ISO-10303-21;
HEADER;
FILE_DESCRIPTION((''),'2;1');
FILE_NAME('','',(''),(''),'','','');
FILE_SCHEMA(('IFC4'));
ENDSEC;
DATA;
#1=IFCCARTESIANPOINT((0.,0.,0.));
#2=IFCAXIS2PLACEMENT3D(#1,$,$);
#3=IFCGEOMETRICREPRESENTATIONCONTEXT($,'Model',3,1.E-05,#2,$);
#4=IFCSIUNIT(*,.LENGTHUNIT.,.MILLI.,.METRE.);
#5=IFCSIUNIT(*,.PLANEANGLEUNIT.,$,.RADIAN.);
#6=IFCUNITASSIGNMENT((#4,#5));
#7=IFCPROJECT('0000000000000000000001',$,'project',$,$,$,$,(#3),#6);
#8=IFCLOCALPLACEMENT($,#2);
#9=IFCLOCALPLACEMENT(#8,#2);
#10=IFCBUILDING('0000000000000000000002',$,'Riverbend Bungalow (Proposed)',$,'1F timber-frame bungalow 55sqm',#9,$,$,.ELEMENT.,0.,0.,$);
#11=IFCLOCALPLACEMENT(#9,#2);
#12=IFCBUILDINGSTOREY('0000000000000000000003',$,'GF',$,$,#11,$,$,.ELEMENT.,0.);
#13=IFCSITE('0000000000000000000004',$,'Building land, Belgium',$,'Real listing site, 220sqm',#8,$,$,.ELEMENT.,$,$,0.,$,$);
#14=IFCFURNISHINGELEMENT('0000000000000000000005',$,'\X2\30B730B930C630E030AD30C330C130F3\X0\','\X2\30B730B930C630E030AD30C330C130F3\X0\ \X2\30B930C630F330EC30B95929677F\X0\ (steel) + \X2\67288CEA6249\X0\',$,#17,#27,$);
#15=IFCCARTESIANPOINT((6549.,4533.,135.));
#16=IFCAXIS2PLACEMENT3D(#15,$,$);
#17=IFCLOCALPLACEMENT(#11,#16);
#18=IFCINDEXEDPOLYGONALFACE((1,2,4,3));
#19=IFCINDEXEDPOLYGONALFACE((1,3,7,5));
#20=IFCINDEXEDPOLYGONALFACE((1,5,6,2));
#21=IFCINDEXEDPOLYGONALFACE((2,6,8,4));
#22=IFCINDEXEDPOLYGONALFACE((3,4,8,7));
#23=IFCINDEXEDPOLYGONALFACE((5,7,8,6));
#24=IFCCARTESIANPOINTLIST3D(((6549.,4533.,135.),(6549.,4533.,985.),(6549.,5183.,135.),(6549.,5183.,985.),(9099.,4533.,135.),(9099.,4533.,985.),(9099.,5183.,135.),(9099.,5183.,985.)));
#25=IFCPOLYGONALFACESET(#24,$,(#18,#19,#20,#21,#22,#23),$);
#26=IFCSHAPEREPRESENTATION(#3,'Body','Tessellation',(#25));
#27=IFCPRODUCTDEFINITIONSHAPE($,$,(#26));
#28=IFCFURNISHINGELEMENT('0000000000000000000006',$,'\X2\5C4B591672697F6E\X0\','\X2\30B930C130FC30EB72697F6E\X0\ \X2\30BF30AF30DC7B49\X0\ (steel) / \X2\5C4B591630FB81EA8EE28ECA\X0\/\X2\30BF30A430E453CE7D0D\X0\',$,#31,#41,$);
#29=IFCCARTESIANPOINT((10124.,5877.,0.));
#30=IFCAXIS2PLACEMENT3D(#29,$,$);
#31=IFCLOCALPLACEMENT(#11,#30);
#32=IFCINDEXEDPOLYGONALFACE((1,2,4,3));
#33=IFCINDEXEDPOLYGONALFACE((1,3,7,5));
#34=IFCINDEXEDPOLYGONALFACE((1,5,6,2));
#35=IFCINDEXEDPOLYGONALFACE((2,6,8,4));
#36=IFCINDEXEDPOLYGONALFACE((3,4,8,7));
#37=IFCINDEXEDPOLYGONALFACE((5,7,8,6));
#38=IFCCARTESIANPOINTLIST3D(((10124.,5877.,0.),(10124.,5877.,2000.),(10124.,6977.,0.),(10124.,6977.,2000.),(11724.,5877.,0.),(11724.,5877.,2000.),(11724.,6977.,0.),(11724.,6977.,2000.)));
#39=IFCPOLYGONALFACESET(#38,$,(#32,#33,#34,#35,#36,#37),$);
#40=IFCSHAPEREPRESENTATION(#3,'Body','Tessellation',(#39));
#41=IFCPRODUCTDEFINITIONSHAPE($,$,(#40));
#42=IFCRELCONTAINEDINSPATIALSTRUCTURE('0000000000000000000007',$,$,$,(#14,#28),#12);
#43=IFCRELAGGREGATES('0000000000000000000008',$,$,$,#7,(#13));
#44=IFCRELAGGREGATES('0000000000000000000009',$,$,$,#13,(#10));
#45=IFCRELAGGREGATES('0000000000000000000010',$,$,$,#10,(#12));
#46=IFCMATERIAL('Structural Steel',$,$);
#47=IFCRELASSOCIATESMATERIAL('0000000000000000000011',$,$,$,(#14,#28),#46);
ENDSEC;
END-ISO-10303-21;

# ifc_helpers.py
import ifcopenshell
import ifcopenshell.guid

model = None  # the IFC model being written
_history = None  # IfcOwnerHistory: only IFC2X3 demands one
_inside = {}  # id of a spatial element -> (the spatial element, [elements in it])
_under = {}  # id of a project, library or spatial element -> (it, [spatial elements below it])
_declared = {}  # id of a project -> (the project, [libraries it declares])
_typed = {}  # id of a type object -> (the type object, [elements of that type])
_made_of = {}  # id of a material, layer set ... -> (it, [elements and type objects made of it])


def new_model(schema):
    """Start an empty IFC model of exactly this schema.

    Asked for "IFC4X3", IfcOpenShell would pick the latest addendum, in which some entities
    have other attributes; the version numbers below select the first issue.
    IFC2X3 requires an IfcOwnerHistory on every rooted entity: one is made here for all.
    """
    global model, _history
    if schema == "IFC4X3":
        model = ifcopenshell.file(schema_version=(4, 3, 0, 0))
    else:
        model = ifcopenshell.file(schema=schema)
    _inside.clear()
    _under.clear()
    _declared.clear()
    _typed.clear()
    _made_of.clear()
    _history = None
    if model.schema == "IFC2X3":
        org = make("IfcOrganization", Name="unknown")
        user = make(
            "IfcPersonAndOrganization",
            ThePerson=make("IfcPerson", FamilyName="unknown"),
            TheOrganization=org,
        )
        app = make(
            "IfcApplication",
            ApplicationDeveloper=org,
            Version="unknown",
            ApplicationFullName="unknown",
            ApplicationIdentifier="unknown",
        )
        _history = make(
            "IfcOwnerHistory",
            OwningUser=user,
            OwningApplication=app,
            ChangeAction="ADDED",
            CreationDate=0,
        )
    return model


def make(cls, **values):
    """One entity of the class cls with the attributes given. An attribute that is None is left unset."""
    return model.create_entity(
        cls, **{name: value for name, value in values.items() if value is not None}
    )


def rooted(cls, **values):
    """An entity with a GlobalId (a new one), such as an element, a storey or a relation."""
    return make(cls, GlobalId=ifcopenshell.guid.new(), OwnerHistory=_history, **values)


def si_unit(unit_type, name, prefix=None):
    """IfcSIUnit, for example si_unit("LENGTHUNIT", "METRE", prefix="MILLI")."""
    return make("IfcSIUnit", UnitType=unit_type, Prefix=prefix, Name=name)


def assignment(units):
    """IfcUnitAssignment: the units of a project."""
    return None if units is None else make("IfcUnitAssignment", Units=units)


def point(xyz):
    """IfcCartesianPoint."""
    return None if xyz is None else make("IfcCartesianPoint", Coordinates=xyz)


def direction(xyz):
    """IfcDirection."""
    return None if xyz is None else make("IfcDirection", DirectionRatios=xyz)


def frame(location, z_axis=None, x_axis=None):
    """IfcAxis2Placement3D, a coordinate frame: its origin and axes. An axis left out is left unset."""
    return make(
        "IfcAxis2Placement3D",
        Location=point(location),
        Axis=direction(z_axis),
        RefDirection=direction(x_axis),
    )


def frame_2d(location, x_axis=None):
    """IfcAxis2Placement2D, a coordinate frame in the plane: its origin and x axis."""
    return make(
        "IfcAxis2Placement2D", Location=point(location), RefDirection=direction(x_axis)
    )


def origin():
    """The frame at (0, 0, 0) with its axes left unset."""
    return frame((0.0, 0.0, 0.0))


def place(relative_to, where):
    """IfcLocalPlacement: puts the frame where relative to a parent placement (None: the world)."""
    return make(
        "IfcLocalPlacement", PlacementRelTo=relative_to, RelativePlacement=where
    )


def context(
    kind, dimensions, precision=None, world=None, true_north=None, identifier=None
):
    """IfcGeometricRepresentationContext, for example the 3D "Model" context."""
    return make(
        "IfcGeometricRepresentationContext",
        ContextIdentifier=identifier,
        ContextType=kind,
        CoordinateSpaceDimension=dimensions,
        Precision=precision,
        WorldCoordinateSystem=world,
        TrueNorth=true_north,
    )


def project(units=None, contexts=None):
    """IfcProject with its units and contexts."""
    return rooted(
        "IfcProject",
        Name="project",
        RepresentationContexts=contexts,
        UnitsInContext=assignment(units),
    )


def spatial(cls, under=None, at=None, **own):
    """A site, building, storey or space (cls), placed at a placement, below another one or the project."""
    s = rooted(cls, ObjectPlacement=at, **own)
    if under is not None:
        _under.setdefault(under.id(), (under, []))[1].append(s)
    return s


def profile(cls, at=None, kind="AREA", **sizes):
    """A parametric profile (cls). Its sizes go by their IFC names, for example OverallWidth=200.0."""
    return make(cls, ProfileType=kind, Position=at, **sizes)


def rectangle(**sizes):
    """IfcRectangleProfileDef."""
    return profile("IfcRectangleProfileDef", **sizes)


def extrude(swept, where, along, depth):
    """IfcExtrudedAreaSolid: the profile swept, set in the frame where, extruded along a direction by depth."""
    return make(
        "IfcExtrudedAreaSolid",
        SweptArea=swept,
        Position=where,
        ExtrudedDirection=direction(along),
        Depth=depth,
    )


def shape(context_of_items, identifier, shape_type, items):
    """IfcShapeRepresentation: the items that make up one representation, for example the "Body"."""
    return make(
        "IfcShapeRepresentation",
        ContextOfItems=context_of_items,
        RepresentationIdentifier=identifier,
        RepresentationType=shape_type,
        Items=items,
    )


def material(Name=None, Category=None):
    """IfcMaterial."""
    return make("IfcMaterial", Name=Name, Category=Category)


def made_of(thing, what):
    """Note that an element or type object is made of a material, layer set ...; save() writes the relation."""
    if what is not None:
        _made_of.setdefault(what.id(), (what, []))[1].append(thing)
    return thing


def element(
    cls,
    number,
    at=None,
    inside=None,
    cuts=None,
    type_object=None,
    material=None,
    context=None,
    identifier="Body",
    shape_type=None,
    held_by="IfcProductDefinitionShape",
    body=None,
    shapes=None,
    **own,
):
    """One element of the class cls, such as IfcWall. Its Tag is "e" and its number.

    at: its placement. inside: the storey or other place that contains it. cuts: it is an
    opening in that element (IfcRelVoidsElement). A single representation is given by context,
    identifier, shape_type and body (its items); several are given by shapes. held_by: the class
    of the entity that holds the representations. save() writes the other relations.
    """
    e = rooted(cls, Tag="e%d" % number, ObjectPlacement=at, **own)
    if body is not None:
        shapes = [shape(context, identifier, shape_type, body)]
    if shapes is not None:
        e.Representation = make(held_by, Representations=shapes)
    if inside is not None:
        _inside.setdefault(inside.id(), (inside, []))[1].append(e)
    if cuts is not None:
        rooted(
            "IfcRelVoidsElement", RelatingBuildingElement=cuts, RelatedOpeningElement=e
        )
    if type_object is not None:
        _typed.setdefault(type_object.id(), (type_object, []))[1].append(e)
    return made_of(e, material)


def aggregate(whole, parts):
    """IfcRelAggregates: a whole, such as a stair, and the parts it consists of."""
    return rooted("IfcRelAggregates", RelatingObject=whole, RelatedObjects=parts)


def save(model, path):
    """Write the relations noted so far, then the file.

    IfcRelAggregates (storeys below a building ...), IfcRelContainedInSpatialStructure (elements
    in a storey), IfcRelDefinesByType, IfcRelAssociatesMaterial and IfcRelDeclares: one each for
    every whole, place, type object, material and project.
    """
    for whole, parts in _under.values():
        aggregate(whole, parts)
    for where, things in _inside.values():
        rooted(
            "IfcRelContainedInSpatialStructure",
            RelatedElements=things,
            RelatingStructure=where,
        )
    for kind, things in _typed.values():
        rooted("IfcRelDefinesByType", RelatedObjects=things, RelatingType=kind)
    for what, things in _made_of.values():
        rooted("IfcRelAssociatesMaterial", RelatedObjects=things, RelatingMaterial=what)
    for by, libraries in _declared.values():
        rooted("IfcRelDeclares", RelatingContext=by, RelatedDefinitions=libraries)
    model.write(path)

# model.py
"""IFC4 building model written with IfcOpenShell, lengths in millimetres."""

from ifc_helpers import new_model, si_unit, frame, frame_2d, origin, place, context, project, spatial, rectangle, extrude, material, element, save


model = new_model("IFC4")

# Units and contexts
model_context = context("Model", 3, precision=1e-05, world=origin())
ifc_project = project(units=[si_unit("LENGTHUNIT", "METRE", prefix="MILLI"), si_unit("PLANEANGLEUNIT", "RADIAN")], contexts=[model_context])

# Site, building, storey
site_placement = place(None, origin())
site = spatial("IfcSite", under=ifc_project, at=site_placement, Name="Building land, Belgium", ObjectType="Real listing site, 220sqm", CompositionType="ELEMENT", RefElevation=0.0)
building_placement = place(site_placement, origin())
building = spatial("IfcBuilding", under=site, at=building_placement, Name="Riverbend Bungalow (Proposed)", ObjectType="1F timber-frame bungalow 55sqm", CompositionType="ELEMENT", ElevationOfRefHeight=0.0, ElevationOfTerrain=0.0)
storey_placement = place(building_placement, origin())
storey = spatial("IfcBuildingStorey", under=building, at=storey_placement, Name="GF", CompositionType="ELEMENT", Elevation=0.0)

# Shared definitions
ifc_material_1 = material(Name="Structural Steel")

# Furnishing elements
furnishing_1_placement = place(storey_placement, frame((6549.0, 4533.0, 135.0)))
element("IfcFurnishingElement", 1, at=furnishing_1_placement, inside=storey, material=ifc_material_1, Name="システムキッチン", Description="システムキッチン ステンレス天板 (steel) + 木質扉", context=model_context, shape_type="SweptSolid", body=[
    extrude(rectangle(XDim=2550.0, YDim=650.0, at=frame_2d((1275.0, 325.0))), frame((6549.0, 4533.0, 135.0)), (0.0, 0.0, 1.0), 850.0),
])
furnishing_2_placement = place(storey_placement, frame((10124.0, 5877.0, 0.0)))
element("IfcFurnishingElement", 2, at=furnishing_2_placement, inside=storey, material=ifc_material_1, Name="屋外物置", Description="スチール物置 タクボ等 (steel) / 屋外・自転車/タイヤ収納", context=model_context, shape_type="SweptSolid", body=[
    extrude(rectangle(XDim=1600.0, YDim=1100.0, at=frame_2d((800.0, 550.0))), frame((10124.0, 5877.0, 0.0)), (0.0, 0.0, 1.0), 2000.0),
])

save(model, "model.ifc")
